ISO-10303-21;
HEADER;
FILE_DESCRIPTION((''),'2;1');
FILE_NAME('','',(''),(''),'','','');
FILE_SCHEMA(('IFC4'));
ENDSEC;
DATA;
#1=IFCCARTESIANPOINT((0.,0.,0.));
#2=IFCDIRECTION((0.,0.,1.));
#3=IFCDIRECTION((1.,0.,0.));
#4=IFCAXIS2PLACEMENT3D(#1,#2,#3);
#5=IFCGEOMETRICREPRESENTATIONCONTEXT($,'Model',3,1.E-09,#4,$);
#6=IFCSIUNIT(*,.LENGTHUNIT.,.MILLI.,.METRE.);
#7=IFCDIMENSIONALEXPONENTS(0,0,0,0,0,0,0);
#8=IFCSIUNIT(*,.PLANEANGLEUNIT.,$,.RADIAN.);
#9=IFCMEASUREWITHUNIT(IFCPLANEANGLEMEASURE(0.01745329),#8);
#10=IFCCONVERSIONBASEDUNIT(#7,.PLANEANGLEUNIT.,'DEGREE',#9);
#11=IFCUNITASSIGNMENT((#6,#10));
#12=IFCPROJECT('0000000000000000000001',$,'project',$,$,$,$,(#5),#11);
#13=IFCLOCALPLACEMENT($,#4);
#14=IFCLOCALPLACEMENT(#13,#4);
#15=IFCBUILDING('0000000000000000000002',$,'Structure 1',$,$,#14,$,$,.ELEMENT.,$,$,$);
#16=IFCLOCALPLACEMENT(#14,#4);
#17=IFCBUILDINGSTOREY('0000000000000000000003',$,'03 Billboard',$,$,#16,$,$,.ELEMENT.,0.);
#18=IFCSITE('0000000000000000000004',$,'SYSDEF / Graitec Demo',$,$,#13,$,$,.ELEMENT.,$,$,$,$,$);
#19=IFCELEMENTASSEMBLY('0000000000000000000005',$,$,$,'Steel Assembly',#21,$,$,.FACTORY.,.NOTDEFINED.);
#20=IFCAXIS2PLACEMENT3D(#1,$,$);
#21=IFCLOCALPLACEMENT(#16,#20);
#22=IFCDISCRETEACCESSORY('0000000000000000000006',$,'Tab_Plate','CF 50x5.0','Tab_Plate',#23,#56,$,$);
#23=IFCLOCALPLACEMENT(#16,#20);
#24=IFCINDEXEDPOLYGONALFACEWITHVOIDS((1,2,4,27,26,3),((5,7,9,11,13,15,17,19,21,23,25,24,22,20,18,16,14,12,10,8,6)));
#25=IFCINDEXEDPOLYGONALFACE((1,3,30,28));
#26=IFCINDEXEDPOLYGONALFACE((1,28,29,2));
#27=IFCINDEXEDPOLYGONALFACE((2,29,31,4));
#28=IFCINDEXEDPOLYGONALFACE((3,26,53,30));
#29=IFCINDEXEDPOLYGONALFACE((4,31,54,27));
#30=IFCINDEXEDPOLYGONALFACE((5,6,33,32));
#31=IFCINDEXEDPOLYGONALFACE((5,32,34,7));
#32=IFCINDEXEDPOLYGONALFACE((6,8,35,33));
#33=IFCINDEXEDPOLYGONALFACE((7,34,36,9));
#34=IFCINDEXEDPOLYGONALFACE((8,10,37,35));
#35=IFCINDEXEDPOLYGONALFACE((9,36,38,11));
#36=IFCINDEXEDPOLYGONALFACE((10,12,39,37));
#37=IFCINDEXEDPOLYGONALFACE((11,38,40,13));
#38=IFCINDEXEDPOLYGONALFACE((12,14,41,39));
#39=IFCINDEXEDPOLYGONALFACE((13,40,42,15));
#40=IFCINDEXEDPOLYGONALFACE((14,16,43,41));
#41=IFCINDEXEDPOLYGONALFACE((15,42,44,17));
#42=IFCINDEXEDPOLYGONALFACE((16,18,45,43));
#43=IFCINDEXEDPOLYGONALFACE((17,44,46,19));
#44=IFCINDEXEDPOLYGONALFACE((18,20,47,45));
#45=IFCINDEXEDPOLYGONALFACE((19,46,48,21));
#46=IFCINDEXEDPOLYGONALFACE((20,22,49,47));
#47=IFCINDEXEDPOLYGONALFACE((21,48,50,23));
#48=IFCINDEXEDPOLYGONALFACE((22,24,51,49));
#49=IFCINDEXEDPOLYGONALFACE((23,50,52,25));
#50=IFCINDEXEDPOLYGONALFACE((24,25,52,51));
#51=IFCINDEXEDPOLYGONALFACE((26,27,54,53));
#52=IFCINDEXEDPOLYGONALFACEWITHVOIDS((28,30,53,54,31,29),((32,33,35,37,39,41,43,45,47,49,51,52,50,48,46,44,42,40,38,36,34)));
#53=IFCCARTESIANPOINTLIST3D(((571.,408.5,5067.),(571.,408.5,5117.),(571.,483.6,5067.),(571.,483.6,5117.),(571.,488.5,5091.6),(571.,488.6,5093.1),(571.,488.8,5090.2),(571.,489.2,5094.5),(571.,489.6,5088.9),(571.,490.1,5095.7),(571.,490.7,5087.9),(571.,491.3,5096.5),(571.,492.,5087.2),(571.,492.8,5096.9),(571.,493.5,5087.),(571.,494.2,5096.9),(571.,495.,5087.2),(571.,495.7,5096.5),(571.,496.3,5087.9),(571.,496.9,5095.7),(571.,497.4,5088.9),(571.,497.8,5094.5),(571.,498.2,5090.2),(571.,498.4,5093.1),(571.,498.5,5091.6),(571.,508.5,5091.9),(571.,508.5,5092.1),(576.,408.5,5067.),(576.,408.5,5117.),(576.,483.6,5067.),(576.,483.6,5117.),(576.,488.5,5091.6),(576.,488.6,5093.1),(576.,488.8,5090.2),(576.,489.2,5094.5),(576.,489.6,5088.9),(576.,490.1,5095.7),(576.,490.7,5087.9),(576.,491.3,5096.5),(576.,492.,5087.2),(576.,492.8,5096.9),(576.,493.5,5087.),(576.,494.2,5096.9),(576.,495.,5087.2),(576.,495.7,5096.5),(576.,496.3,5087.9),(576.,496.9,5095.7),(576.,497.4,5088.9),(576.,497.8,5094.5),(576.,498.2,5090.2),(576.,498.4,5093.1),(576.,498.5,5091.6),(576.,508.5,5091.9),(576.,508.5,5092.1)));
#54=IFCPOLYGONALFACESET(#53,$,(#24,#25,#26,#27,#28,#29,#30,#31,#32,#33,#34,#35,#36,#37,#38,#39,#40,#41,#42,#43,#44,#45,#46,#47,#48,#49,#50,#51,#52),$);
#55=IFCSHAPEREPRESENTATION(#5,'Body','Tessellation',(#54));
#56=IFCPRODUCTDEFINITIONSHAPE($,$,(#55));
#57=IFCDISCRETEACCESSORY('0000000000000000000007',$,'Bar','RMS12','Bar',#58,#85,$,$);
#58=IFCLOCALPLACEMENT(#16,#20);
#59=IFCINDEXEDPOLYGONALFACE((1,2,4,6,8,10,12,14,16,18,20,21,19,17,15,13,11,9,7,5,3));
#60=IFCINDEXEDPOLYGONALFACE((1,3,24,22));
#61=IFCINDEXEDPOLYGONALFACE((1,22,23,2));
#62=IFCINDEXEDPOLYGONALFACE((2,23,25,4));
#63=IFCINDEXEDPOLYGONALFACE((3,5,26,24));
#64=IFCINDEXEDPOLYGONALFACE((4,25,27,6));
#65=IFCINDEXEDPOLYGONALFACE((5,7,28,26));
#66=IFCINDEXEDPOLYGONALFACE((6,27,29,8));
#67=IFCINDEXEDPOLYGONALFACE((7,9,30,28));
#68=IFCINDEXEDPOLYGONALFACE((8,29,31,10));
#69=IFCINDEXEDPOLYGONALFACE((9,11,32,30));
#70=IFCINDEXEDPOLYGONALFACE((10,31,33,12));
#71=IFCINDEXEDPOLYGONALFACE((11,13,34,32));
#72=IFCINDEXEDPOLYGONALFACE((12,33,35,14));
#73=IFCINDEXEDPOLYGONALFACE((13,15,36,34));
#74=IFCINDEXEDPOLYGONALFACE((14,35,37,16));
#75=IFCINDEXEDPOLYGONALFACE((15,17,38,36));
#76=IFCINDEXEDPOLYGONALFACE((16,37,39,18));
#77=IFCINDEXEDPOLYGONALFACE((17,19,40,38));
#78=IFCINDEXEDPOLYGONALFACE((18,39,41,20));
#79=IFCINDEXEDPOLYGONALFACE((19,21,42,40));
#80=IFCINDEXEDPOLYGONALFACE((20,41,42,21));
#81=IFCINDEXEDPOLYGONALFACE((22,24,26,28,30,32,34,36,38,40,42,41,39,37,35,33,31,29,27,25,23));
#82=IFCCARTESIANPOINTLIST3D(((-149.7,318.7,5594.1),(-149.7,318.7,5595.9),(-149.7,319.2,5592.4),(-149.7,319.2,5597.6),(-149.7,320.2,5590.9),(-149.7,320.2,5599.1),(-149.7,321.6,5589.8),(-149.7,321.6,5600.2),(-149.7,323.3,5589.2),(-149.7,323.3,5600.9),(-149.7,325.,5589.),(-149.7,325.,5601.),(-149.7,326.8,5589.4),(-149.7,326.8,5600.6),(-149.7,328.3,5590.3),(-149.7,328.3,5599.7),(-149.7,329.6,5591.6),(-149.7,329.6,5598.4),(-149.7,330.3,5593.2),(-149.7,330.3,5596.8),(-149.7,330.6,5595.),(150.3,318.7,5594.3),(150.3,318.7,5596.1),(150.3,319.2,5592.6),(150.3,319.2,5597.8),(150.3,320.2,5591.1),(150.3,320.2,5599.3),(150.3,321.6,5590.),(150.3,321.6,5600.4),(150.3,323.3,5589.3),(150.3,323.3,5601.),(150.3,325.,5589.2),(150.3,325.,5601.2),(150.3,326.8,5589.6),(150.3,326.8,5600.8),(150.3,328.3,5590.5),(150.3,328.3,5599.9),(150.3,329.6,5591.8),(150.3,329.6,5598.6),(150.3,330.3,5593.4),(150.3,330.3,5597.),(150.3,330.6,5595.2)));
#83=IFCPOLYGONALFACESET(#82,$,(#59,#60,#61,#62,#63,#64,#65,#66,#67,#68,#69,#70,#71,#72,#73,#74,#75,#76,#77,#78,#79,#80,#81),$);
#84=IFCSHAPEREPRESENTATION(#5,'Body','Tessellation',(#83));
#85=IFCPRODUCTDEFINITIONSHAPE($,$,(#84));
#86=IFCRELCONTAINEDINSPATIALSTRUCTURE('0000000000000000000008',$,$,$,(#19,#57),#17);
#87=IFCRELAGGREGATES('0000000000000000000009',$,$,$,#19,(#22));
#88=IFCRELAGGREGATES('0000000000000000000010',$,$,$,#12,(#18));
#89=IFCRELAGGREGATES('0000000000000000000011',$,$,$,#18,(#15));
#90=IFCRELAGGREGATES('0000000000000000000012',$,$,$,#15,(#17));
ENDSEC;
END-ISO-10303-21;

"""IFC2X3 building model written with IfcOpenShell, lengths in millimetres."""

from ifc_helpers import new_model, entity, si_unit, converted_unit, point, frame, frame_2d, origin, origin_with_axes, origin_2d, place, context, project, spatial, circle_curve, line_curve, trimmed, segment, composite_curve, rectangle, circle, outline, extrude, element, aggregate, save


model = new_model("IFC2X3")

# Units and contexts
model_context = context("Model", 3, precision=1e-09, world=origin_with_axes())
ifc_project = project(units=[si_unit("LENGTHUNIT", "METRE", prefix="MILLI"), converted_unit("PLANEANGLEUNIT", "DEGREE", entity("IfcPlaneAngleMeasure", 0.01745329), si_unit("PLANEANGLEUNIT", "RADIAN"), dimensions=[0, 0, 0, 0, 0, 0, 0])], contexts=[model_context])

# Site, building, storey
site_placement = place(None, origin_with_axes())
site = spatial("IfcSite", under=ifc_project, at=site_placement, Name="SYSDEF / Graitec Demo", CompositionType="ELEMENT")
building_placement = place(site_placement, origin_with_axes())
building = spatial("IfcBuilding", under=site, at=building_placement, Name="Structure 1", CompositionType="ELEMENT")
storey_placement = place(building_placement, origin_with_axes())
storey = spatial("IfcBuildingStorey", under=building, at=storey_placement, Name="03 Billboard", CompositionType="ELEMENT", Elevation=0.0)

# Element assembly, discrete accessory, openings
assembly_1_placement = place(None, frame((546.0, 433.5, 3973.6), z_axis=(0.0, 0.0, 1.0), x_axis=(0.0, 1.0, 0.0)))
assembly_1 = element("IfcElementAssembly", 1, at=assembly_1_placement, inside=storey, ObjectType="Steel Assembly", AssemblyPlace="FACTORY", PredefinedType="NOTDEFINED")
discrete_accessory_1_placement = place(assembly_1_placement, frame((-25.0, -27.5, 1118.4), z_axis=(1.0, 0.000002, 0.0), x_axis=(-0.000002, 1.0, 0.0)))
discrete_accessory_1 = element("IfcDiscreteAccessory", 2, at=discrete_accessory_1_placement, Name="Tab_Plate", Description="CF 50x5.0", ObjectType="Tab_Plate", context=model_context, shape_type="SweptSolid", body=[
    extrude(rectangle(XDim=5.0, YDim=50.0, at=origin_2d()), origin(), (0.0, 0.0, 1.0), 100.0),
])
opening_1_placement = place(discrete_accessory_1_placement, frame((-3.0, 0.0, 90.0), z_axis=(-1.0, 0.0, 0.0), x_axis=(0.0, -1.0, 0.0)))
element("IfcOpeningElement", 3, at=opening_1_placement, cuts=discrete_accessory_1, ObjectType="Opening", context=model_context, shape_type="SweptSolid", body=[
    extrude(circle(Radius=5.0, at=frame_2d((0.0, -5.0), x_axis=(1.0, 0.0))), origin(), (0.0, 0.0, -1.0), 6.0),
])
opening_2_placement = place(discrete_accessory_1_placement, frame((2.5, 25.0, 100.0), z_axis=(-1.0, 0.0, 0.0), x_axis=(0.0, 0.0, -1.0)))
element("IfcOpeningElement", 4, at=opening_2_placement, cuts=discrete_accessory_1, ObjectType="Opening", context=model_context, shape_type="SweptSolid", body=[
    extrude(outline(composite_curve([segment(trimmed(line_curve((0.0, 0.0), (1.0, 0.0), 24.9), [point((0.0, 0.0))], [point((24.9, 0.0))], True, "CARTESIAN"), True, "CONTINUOUS"), segment(trimmed(circle_curve(frame_2d((24.9, 24.9), x_axis=(-1.0, 0.0)), 24.9), [point((24.9, 0.0))], [point((0.0, 24.9))], False, "CARTESIAN"), True, "CONTINUOUS"), segment(trimmed(line_curve((0.0, 24.9), (0.0, -1.0), 24.9), [point((0.0, 24.9))], [point((0.0, 0.0))], True, "CARTESIAN"), True, "CONTINUOUS")], self_intersect=False)), origin(), (0.0, 0.0, 1.0), 5.0),
])
opening_3_placement = place(discrete_accessory_1_placement, frame((-2.5, -25.0, 100.0), z_axis=(1.0, 0.0, 0.0), x_axis=(0.0, 0.0, -1.0)))
element("IfcOpeningElement", 5, at=opening_3_placement, cuts=discrete_accessory_1, ObjectType="Opening", context=model_context, shape_type="SweptSolid", body=[
    extrude(outline(composite_curve([segment(trimmed(line_curve((0.0, 0.0), (1.0, 0.0), 24.9), [point((0.0, 0.0))], [point((24.9, 0.0))], True, "CARTESIAN"), True, "CONTINUOUS"), segment(trimmed(circle_curve(frame_2d((24.9, 24.9), x_axis=(-1.0, 0.0)), 24.9), [point((24.9, 0.0))], [point((0.0, 24.9))], False, "CARTESIAN"), True, "CONTINUOUS"), segment(trimmed(line_curve((0.0, 24.9), (0.0, -1.0), 24.9), [point((0.0, 24.9))], [point((0.0, 0.0))], True, "CARTESIAN"), True, "CONTINUOUS")], self_intersect=False)), origin(), (0.0, 0.0, 1.0), 5.0),
])

# Discrete accessory
discrete_accessory_2_placement = place(None, frame((150.3, 324.6, 5595.2), z_axis=(1.0, -0.000002, 0.000658), x_axis=(0.000002, 1.0, -0.000019)))
element("IfcDiscreteAccessory", 6, at=discrete_accessory_2_placement, inside=storey, Name="Bar", Description="RMS12", ObjectType="Bar", context=model_context, shape_type="SweptSolid", body=[
    extrude(circle(Radius=6.0, at=origin_2d()), origin(), (0.0, 0.0, -1.0), 300.0),
])

aggregate(assembly_1, [discrete_accessory_1])

save(model, "model.ifc")
